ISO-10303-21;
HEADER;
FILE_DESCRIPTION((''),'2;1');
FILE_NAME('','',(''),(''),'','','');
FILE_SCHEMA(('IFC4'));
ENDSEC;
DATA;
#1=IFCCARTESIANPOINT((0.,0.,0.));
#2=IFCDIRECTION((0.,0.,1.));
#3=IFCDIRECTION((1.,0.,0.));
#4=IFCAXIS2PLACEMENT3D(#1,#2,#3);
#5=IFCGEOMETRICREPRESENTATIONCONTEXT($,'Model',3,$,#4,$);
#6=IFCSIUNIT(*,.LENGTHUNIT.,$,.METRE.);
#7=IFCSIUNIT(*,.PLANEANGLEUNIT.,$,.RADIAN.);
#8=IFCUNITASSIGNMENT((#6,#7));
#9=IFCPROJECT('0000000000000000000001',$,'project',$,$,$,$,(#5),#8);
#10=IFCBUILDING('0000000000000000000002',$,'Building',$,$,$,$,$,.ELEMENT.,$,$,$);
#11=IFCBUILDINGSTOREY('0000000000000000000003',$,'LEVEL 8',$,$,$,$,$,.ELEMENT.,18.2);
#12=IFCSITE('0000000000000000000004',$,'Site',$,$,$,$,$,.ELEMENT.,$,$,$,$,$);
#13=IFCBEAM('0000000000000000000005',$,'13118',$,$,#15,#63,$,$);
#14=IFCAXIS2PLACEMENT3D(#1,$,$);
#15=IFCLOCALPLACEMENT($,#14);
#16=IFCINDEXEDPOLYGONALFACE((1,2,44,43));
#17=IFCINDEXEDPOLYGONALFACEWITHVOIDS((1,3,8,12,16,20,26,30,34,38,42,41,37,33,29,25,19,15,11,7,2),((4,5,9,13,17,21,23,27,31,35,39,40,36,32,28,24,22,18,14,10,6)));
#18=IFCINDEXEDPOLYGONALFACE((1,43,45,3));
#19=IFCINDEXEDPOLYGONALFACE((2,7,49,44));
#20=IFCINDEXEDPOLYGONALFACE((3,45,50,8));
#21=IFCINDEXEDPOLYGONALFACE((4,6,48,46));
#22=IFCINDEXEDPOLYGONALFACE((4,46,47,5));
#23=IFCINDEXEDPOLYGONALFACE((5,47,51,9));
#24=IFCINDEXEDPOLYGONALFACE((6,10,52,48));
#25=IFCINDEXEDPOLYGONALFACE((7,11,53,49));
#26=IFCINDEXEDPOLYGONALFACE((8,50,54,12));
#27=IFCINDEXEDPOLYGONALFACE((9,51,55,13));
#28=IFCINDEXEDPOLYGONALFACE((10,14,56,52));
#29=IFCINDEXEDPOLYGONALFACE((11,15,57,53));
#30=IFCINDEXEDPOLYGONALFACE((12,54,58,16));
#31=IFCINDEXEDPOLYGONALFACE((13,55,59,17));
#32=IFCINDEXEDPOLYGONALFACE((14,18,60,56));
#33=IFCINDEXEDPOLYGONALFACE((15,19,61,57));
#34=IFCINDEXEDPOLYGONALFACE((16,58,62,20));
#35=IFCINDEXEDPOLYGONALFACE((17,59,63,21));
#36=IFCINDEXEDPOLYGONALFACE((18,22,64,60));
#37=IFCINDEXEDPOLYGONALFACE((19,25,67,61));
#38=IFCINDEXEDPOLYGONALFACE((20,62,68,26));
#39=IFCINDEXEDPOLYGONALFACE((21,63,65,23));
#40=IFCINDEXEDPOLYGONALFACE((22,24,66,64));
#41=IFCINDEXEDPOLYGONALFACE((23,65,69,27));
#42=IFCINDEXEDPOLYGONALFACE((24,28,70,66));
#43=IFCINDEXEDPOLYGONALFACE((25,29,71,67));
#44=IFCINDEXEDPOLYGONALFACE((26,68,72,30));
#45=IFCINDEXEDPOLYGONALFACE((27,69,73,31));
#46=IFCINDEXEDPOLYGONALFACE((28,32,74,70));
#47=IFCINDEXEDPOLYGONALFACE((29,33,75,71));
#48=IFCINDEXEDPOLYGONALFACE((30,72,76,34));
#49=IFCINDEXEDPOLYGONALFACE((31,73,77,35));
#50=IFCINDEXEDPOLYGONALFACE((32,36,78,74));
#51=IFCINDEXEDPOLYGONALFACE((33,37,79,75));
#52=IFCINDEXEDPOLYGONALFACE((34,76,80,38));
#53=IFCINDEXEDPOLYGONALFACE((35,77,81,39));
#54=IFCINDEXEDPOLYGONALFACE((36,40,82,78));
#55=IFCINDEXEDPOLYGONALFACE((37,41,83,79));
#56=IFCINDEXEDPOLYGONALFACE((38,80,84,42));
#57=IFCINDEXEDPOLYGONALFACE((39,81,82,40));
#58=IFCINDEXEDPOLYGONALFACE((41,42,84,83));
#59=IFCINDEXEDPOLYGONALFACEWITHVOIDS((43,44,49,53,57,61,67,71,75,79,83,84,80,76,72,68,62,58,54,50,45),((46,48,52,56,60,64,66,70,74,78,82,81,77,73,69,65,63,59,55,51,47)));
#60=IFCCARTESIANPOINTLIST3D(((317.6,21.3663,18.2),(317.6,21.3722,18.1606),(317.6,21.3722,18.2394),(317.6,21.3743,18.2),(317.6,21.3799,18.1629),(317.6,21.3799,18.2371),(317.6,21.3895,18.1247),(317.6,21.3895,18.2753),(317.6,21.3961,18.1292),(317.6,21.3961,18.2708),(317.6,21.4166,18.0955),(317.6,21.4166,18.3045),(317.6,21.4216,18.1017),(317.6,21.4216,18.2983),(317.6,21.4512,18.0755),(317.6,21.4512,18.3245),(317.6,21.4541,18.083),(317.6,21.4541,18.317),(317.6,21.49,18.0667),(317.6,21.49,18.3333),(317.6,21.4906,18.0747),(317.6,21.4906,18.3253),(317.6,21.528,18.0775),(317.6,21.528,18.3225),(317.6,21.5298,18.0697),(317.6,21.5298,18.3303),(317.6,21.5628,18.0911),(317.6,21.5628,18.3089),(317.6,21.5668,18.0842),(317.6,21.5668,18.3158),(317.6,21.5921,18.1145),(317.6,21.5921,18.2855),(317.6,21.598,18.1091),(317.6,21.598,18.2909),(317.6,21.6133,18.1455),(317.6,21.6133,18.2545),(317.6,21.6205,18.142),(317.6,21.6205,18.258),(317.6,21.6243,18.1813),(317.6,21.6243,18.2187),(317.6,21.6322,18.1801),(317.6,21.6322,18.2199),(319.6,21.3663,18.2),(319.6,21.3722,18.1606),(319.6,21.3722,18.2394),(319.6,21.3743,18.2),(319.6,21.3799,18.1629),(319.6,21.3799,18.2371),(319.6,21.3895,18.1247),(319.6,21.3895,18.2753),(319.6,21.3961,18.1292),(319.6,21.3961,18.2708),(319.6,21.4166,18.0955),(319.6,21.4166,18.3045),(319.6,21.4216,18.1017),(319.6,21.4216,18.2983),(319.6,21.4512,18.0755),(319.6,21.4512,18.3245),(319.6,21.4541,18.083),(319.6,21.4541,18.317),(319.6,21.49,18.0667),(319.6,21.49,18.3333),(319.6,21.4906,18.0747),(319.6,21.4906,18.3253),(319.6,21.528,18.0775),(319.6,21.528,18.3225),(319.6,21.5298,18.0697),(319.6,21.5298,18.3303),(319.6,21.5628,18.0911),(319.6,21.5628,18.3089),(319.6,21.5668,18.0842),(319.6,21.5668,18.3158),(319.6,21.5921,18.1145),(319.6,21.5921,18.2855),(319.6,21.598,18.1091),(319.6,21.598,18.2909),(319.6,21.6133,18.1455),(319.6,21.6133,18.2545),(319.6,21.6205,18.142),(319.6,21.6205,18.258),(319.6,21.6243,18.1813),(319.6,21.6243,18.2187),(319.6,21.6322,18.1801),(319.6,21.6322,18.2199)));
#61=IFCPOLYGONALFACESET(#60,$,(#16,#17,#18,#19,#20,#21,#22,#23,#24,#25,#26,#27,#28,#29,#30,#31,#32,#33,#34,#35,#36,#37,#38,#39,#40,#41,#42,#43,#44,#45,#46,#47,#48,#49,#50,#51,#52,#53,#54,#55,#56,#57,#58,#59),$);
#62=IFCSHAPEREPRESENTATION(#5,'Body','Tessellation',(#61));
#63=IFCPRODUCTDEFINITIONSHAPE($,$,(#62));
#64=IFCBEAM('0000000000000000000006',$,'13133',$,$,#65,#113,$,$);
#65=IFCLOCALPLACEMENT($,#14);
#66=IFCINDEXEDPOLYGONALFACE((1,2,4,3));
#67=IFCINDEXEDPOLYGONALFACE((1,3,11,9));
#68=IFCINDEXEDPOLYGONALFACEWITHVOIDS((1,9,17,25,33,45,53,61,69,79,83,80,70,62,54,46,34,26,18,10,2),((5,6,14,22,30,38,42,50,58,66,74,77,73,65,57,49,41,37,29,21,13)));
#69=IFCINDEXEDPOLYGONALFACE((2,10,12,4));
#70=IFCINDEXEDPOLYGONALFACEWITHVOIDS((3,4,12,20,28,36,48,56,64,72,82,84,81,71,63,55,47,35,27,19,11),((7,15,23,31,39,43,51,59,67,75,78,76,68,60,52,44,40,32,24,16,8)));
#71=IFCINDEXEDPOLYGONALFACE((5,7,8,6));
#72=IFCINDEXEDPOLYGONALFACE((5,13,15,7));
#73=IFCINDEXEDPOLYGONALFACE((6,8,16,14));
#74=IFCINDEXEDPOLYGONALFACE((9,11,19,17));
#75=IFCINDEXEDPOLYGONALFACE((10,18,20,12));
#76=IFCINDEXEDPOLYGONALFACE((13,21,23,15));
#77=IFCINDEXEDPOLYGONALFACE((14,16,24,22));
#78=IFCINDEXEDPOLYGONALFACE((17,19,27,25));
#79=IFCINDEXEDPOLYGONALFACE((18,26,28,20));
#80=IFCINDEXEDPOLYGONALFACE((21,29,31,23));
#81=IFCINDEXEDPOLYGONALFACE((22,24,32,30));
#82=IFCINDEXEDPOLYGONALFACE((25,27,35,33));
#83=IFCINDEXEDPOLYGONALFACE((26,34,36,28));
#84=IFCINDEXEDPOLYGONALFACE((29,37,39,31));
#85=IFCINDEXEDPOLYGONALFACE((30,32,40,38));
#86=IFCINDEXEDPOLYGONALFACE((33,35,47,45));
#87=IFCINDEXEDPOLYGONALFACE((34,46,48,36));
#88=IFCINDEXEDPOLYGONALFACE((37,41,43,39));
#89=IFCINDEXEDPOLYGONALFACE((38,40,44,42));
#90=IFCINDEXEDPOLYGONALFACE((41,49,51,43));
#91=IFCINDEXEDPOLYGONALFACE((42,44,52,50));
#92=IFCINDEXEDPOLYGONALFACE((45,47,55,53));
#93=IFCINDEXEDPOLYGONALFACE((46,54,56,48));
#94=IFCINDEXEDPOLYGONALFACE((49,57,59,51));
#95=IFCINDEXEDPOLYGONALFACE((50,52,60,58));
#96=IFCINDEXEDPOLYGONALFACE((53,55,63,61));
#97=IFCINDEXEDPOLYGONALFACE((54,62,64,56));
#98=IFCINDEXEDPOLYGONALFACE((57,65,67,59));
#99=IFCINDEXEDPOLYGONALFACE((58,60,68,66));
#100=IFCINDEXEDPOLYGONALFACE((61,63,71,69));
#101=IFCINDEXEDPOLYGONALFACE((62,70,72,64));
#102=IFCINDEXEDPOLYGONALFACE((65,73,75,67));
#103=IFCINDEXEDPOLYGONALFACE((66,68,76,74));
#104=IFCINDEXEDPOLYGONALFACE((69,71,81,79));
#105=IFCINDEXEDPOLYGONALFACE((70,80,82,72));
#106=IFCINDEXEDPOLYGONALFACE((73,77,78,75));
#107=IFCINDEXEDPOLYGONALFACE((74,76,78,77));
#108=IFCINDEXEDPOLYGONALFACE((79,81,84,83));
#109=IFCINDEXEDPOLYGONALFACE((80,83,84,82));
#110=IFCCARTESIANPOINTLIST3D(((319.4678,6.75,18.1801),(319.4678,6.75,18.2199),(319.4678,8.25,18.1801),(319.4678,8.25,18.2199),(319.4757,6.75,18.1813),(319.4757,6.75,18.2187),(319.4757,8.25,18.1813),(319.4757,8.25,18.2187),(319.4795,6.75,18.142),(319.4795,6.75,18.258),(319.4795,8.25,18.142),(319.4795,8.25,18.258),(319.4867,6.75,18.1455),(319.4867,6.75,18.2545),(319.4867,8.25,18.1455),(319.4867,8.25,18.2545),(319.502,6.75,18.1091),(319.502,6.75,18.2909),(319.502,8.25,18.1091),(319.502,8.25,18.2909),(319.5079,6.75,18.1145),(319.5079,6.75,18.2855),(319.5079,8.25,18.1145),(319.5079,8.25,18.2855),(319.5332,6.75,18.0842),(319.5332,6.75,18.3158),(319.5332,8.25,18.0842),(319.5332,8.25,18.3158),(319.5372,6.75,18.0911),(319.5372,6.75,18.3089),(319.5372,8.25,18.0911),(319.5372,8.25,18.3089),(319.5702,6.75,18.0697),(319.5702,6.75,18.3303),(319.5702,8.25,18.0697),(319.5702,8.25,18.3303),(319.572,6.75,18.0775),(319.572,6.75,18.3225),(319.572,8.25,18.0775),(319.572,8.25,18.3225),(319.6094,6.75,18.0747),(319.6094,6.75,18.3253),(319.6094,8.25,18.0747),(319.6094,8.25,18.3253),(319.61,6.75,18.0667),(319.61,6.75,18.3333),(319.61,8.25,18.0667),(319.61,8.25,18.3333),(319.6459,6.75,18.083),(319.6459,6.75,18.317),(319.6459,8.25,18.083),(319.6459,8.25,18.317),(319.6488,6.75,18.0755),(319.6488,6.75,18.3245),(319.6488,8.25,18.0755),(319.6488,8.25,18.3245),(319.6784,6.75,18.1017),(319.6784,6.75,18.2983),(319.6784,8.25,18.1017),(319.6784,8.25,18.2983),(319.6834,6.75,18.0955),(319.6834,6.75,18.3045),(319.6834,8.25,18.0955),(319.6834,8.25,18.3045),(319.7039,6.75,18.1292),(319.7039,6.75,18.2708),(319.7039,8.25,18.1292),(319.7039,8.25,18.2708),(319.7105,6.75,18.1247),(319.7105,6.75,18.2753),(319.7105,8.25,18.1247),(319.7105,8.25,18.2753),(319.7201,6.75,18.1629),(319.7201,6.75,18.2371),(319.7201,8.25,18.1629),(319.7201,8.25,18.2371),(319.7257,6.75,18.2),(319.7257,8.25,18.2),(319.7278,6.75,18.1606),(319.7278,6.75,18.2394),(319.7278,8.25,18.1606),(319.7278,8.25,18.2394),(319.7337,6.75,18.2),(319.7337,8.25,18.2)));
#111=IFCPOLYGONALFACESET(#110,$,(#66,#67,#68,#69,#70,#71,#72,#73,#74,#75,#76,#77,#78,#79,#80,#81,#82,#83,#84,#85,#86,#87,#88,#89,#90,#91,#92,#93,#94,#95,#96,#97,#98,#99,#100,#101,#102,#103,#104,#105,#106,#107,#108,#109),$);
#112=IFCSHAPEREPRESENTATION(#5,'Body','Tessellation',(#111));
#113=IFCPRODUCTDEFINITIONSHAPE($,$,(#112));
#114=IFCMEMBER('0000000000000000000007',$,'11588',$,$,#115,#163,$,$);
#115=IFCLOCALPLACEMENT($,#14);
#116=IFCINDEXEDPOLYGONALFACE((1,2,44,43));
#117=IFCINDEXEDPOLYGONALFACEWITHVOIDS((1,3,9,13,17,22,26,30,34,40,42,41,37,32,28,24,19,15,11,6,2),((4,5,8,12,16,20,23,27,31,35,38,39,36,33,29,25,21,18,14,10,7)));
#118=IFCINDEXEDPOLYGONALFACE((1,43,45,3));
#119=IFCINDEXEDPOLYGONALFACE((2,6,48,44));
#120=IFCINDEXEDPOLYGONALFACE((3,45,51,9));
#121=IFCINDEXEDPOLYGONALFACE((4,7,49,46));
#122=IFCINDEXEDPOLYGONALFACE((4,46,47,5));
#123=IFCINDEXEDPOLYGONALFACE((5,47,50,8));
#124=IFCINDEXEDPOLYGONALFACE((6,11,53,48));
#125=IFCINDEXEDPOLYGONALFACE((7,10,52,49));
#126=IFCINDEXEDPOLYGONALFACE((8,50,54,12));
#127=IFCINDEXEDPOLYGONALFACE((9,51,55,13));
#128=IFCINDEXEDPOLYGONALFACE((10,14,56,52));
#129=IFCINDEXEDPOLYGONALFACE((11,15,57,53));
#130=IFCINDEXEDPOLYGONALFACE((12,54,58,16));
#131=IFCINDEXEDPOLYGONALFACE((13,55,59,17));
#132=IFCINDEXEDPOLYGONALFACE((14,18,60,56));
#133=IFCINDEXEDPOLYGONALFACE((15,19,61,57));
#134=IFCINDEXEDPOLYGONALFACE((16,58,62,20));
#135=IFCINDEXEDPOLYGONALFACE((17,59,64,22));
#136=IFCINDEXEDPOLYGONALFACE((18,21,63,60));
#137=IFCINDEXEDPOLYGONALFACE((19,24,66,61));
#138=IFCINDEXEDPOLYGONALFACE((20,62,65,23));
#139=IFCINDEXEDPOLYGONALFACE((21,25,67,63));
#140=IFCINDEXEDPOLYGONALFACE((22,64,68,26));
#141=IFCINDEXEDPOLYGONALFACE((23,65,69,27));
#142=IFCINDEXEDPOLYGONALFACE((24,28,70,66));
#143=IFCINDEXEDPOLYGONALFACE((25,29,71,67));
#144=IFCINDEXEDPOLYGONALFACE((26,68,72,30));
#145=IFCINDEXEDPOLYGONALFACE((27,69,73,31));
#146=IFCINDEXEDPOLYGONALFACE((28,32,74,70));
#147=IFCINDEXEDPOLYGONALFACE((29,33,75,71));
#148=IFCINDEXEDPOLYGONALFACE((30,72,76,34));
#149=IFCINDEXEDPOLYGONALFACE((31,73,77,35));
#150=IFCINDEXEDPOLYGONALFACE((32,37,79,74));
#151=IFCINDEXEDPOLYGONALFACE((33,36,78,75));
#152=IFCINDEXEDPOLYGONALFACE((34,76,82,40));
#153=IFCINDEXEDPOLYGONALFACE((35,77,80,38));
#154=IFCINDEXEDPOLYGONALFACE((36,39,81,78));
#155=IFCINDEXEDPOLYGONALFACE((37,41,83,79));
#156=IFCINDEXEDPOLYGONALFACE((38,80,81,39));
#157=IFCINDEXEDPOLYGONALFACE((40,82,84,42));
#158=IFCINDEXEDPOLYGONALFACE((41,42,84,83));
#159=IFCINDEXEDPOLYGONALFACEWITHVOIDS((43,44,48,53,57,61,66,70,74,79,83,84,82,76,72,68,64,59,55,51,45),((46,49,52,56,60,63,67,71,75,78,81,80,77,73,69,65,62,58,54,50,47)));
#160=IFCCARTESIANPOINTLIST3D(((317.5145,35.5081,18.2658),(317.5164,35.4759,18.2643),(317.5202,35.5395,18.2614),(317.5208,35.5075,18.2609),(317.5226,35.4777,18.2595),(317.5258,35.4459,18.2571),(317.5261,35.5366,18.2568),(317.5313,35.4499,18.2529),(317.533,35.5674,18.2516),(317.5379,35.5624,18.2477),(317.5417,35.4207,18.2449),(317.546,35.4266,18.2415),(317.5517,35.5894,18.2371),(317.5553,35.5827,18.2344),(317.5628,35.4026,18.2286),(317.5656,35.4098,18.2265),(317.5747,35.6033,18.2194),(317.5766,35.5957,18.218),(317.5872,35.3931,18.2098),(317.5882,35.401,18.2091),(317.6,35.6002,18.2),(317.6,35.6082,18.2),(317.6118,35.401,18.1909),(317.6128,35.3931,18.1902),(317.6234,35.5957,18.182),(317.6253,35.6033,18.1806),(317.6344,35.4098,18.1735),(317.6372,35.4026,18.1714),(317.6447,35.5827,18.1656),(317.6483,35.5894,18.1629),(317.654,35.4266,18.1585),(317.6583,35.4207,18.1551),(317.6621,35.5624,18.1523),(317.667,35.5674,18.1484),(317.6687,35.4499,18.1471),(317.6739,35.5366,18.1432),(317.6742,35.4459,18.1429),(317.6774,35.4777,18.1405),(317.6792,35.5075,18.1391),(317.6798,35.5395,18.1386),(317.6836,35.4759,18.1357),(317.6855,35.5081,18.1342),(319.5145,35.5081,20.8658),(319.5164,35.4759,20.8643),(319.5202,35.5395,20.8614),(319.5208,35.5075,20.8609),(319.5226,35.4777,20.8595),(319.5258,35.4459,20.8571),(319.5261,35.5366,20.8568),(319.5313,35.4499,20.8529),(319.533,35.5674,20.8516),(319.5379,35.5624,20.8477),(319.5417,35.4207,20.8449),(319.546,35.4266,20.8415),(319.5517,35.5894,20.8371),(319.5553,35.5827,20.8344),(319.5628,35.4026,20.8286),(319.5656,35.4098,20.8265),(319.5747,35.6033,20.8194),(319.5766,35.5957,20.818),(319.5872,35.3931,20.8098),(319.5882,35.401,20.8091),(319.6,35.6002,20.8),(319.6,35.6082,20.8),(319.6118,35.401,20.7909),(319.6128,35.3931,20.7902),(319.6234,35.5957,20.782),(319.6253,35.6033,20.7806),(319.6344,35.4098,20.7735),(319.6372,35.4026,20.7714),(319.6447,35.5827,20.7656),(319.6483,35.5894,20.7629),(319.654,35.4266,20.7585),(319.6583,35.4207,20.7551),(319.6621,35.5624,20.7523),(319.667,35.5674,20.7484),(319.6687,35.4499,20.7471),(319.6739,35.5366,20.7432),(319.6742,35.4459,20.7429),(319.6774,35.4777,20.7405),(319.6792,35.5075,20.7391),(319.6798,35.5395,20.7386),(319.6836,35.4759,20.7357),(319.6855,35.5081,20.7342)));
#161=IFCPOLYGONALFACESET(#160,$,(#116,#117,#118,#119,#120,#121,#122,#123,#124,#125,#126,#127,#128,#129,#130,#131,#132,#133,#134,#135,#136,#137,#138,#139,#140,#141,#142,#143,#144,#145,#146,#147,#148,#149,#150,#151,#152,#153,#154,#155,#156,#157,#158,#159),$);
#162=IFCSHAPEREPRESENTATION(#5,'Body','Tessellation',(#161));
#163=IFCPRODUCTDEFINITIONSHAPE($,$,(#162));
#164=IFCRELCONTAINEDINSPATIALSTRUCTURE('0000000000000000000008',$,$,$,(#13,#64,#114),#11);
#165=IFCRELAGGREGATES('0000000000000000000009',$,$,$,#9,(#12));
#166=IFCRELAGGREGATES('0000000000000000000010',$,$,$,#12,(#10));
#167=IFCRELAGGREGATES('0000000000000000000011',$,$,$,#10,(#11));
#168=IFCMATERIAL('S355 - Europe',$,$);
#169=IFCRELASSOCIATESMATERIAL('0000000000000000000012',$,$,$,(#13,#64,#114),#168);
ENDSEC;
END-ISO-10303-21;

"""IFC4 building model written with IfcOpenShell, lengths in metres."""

from ifc_helpers import new_model, si_unit, frame, origin_with_axes, origin_2d_with_axis, place, context, project, spatial, hollow_circle, extrude, material, material_profile, profile_set, profile_usage, element, save


model = new_model("IFC4")

# Units and contexts
model_context = context("Model", 3, world=origin_with_axes())
ifc_project = project(units=[si_unit("LENGTHUNIT", "METRE"), si_unit("PLANEANGLEUNIT", "RADIAN")], contexts=[model_context])

# Site, building, storey
site = spatial("IfcSite", under=ifc_project, Name="Site", CompositionType="ELEMENT")
building = spatial("IfcBuilding", under=site, Name="Building", CompositionType="ELEMENT")
storey = spatial("IfcBuildingStorey", under=building, Name="LEVEL 8", CompositionType="ELEMENT", Elevation=18.2)

# Shared definitions
ifc_material = material(Name="S355 - Europe")

# Beams
ifc_material_profile_1 = material_profile(ifc_material, hollow_circle(Radius=0.1337, WallThickness=0.008, at=origin_2d_with_axis()))
ifc_profile_set_1 = profile_set([ifc_material_profile_1])
ifc_profile_usage_1 = profile_usage(ifc_profile_set_1, cardinal=10)
beam_1_placement = place(None, frame((319.6, 21.5, 18.2), z_axis=(-1.0, 0.0, 0.0), x_axis=(0.0, -1.0, 0.0)))
element("IfcBeam", 1, at=beam_1_placement, inside=storey, material=ifc_profile_usage_1, Name="13118", context=model_context, shape_type="SweptSolid", body=[
    extrude(hollow_circle(Radius=0.1337, WallThickness=0.008, at=origin_2d_with_axis()), origin_with_axes(), (0.0, 0.0, 1.0), 2.0),
])
ifc_material_profile_2 = material_profile(ifc_material, hollow_circle(Radius=0.1337, WallThickness=0.008, at=origin_2d_with_axis()))
ifc_profile_set_2 = profile_set([ifc_material_profile_2])
ifc_profile_usage_2 = profile_usage(ifc_profile_set_2, cardinal=10)
beam_2_placement = place(None, frame((319.6, 8.25, 18.2), z_axis=(0.0, -1.0, 0.0), x_axis=(1.0, 0.0, 0.0)))
element("IfcBeam", 2, at=beam_2_placement, inside=storey, material=ifc_profile_usage_2, Name="13133", context=model_context, shape_type="SweptSolid", body=[
    extrude(hollow_circle(Radius=0.1337, WallThickness=0.008, at=origin_2d_with_axis()), origin_with_axes(), (0.0, 0.0, 1.0), 1.5),
])

# Member
ifc_material_profile_3 = material_profile(ifc_material, hollow_circle(Radius=0.1081, WallThickness=0.008, at=origin_2d_with_axis()))
ifc_profile_set_3 = profile_set([ifc_material_profile_3])
ifc_profile_usage_3 = profile_usage(ifc_profile_set_3, cardinal=10)
member_1_placement = place(None, frame((317.6, 35.5, 18.2), z_axis=(0.609711, 0.0, 0.792624), x_axis=(0.0, 1.0, 0.0)))
element("IfcMember", 3, at=member_1_placement, inside=storey, material=ifc_profile_usage_3, Name="11588", context=model_context, shape_type="SweptSolid", body=[
    extrude(hollow_circle(Radius=0.1081, WallThickness=0.008, at=origin_2d_with_axis()), origin_with_axes(), (0.0, 0.0, 1.0), 3.2802),
])

save(model, "model.ifc")
